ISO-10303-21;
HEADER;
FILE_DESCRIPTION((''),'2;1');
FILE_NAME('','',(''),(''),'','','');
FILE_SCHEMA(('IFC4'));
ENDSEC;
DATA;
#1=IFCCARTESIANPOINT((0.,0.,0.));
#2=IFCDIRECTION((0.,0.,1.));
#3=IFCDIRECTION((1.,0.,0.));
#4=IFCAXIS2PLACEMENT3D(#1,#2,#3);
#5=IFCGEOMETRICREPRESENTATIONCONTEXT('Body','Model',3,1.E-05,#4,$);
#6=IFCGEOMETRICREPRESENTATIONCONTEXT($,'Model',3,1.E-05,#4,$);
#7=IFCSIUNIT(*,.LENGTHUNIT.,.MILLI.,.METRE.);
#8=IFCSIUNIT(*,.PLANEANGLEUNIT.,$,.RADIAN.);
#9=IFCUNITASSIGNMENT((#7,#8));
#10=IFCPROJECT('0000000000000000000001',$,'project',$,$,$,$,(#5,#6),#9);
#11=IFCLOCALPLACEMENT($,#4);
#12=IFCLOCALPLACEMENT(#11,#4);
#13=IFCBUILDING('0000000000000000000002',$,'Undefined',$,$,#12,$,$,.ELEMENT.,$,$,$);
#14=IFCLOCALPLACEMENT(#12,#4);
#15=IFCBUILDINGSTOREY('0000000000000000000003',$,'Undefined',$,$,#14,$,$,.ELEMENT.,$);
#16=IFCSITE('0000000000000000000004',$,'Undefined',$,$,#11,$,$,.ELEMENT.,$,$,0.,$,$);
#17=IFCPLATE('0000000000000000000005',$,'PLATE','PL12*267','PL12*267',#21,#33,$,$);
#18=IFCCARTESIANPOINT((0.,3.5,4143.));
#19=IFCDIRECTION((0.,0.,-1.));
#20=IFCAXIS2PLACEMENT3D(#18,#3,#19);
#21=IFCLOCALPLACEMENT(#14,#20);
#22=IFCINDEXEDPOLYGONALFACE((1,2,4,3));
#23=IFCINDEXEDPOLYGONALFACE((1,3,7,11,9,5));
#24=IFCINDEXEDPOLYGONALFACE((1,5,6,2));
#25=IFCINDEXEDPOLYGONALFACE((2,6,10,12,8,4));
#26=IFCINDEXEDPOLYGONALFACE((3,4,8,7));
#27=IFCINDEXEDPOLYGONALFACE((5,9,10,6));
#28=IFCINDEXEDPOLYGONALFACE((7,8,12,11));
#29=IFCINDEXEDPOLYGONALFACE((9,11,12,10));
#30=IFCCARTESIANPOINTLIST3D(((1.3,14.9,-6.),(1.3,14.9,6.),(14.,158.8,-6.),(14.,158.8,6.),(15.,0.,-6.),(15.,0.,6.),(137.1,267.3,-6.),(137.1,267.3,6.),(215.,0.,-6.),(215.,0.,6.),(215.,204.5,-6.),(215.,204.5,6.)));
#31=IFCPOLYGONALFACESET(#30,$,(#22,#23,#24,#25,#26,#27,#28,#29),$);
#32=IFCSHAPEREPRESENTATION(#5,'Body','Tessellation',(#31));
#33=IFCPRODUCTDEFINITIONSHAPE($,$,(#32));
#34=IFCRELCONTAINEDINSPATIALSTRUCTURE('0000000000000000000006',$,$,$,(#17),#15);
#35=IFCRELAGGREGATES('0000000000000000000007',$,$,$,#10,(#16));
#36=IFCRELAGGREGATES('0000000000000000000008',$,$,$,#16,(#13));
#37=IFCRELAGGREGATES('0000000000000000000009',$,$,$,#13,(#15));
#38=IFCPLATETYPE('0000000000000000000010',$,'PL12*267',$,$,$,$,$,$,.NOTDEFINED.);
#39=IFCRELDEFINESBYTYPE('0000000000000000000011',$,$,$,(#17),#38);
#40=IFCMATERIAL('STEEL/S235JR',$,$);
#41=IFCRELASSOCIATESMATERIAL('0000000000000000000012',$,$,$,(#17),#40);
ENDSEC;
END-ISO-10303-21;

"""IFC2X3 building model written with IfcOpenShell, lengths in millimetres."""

from ifc_helpers import new_model, si_unit, frame, origin_with_axes, place, context, project, spatial, polyline, outline, extrude, material, type_object, element, save


model = new_model("IFC2X3")

# Units and contexts
model_context_1 = context("Model", 3, precision=1e-05, world=origin_with_axes(), identifier="Body")
model_context_2 = context("Model", 3, precision=1e-05, world=origin_with_axes())
ifc_project = project(units=[si_unit("LENGTHUNIT", "METRE", prefix="MILLI"), si_unit("PLANEANGLEUNIT", "RADIAN")], contexts=[model_context_1, model_context_2])

# Site, building, storey
site_placement = place(None, origin_with_axes())
site = spatial("IfcSite", under=ifc_project, at=site_placement, Name="Undefined", CompositionType="ELEMENT", RefElevation=0.0)
building_placement = place(site_placement, origin_with_axes())
building = spatial("IfcBuilding", under=site, at=building_placement, Name="Undefined", CompositionType="ELEMENT")
storey_placement = place(building_placement, origin_with_axes())
storey = spatial("IfcBuildingStorey", under=building, at=storey_placement, Name="Undefined", CompositionType="ELEMENT")

# Shared definitions
ifc_material = material(Name="STEEL/S235JR")

# Plate
plate_type_1 = type_object("IfcPlateType", Name="PL12*267", PredefinedType="NOTDEFINED")
plate_1_placement = place(storey_placement, frame((0.0, 3.5, 4143.0), z_axis=(1.0, 0.0, 0.0), x_axis=(0.0, 0.0, -1.0)))
element("IfcPlate", 1, at=plate_1_placement, inside=storey, type_object=plate_type_1, material=ifc_material, Name="PLATE", Description="PL12*267", ObjectType="PL12*267", context=model_context_1, shape_type="SweptSolid", body=[
    extrude(outline(polyline([(1.3, 14.9), (15.0, 0.0), (215.0, 0.0), (215.0, 204.5), (137.1, 267.3), (14.0, 158.8), (1.3, 14.9)])), frame((0.0, 0.0, -6.0), z_axis=(0.0, 0.0, 1.0), x_axis=(1.0, 0.0, 0.0)), (0.0, 0.0, 1.0), 12.0),
])

save(model, "model.ifc")
